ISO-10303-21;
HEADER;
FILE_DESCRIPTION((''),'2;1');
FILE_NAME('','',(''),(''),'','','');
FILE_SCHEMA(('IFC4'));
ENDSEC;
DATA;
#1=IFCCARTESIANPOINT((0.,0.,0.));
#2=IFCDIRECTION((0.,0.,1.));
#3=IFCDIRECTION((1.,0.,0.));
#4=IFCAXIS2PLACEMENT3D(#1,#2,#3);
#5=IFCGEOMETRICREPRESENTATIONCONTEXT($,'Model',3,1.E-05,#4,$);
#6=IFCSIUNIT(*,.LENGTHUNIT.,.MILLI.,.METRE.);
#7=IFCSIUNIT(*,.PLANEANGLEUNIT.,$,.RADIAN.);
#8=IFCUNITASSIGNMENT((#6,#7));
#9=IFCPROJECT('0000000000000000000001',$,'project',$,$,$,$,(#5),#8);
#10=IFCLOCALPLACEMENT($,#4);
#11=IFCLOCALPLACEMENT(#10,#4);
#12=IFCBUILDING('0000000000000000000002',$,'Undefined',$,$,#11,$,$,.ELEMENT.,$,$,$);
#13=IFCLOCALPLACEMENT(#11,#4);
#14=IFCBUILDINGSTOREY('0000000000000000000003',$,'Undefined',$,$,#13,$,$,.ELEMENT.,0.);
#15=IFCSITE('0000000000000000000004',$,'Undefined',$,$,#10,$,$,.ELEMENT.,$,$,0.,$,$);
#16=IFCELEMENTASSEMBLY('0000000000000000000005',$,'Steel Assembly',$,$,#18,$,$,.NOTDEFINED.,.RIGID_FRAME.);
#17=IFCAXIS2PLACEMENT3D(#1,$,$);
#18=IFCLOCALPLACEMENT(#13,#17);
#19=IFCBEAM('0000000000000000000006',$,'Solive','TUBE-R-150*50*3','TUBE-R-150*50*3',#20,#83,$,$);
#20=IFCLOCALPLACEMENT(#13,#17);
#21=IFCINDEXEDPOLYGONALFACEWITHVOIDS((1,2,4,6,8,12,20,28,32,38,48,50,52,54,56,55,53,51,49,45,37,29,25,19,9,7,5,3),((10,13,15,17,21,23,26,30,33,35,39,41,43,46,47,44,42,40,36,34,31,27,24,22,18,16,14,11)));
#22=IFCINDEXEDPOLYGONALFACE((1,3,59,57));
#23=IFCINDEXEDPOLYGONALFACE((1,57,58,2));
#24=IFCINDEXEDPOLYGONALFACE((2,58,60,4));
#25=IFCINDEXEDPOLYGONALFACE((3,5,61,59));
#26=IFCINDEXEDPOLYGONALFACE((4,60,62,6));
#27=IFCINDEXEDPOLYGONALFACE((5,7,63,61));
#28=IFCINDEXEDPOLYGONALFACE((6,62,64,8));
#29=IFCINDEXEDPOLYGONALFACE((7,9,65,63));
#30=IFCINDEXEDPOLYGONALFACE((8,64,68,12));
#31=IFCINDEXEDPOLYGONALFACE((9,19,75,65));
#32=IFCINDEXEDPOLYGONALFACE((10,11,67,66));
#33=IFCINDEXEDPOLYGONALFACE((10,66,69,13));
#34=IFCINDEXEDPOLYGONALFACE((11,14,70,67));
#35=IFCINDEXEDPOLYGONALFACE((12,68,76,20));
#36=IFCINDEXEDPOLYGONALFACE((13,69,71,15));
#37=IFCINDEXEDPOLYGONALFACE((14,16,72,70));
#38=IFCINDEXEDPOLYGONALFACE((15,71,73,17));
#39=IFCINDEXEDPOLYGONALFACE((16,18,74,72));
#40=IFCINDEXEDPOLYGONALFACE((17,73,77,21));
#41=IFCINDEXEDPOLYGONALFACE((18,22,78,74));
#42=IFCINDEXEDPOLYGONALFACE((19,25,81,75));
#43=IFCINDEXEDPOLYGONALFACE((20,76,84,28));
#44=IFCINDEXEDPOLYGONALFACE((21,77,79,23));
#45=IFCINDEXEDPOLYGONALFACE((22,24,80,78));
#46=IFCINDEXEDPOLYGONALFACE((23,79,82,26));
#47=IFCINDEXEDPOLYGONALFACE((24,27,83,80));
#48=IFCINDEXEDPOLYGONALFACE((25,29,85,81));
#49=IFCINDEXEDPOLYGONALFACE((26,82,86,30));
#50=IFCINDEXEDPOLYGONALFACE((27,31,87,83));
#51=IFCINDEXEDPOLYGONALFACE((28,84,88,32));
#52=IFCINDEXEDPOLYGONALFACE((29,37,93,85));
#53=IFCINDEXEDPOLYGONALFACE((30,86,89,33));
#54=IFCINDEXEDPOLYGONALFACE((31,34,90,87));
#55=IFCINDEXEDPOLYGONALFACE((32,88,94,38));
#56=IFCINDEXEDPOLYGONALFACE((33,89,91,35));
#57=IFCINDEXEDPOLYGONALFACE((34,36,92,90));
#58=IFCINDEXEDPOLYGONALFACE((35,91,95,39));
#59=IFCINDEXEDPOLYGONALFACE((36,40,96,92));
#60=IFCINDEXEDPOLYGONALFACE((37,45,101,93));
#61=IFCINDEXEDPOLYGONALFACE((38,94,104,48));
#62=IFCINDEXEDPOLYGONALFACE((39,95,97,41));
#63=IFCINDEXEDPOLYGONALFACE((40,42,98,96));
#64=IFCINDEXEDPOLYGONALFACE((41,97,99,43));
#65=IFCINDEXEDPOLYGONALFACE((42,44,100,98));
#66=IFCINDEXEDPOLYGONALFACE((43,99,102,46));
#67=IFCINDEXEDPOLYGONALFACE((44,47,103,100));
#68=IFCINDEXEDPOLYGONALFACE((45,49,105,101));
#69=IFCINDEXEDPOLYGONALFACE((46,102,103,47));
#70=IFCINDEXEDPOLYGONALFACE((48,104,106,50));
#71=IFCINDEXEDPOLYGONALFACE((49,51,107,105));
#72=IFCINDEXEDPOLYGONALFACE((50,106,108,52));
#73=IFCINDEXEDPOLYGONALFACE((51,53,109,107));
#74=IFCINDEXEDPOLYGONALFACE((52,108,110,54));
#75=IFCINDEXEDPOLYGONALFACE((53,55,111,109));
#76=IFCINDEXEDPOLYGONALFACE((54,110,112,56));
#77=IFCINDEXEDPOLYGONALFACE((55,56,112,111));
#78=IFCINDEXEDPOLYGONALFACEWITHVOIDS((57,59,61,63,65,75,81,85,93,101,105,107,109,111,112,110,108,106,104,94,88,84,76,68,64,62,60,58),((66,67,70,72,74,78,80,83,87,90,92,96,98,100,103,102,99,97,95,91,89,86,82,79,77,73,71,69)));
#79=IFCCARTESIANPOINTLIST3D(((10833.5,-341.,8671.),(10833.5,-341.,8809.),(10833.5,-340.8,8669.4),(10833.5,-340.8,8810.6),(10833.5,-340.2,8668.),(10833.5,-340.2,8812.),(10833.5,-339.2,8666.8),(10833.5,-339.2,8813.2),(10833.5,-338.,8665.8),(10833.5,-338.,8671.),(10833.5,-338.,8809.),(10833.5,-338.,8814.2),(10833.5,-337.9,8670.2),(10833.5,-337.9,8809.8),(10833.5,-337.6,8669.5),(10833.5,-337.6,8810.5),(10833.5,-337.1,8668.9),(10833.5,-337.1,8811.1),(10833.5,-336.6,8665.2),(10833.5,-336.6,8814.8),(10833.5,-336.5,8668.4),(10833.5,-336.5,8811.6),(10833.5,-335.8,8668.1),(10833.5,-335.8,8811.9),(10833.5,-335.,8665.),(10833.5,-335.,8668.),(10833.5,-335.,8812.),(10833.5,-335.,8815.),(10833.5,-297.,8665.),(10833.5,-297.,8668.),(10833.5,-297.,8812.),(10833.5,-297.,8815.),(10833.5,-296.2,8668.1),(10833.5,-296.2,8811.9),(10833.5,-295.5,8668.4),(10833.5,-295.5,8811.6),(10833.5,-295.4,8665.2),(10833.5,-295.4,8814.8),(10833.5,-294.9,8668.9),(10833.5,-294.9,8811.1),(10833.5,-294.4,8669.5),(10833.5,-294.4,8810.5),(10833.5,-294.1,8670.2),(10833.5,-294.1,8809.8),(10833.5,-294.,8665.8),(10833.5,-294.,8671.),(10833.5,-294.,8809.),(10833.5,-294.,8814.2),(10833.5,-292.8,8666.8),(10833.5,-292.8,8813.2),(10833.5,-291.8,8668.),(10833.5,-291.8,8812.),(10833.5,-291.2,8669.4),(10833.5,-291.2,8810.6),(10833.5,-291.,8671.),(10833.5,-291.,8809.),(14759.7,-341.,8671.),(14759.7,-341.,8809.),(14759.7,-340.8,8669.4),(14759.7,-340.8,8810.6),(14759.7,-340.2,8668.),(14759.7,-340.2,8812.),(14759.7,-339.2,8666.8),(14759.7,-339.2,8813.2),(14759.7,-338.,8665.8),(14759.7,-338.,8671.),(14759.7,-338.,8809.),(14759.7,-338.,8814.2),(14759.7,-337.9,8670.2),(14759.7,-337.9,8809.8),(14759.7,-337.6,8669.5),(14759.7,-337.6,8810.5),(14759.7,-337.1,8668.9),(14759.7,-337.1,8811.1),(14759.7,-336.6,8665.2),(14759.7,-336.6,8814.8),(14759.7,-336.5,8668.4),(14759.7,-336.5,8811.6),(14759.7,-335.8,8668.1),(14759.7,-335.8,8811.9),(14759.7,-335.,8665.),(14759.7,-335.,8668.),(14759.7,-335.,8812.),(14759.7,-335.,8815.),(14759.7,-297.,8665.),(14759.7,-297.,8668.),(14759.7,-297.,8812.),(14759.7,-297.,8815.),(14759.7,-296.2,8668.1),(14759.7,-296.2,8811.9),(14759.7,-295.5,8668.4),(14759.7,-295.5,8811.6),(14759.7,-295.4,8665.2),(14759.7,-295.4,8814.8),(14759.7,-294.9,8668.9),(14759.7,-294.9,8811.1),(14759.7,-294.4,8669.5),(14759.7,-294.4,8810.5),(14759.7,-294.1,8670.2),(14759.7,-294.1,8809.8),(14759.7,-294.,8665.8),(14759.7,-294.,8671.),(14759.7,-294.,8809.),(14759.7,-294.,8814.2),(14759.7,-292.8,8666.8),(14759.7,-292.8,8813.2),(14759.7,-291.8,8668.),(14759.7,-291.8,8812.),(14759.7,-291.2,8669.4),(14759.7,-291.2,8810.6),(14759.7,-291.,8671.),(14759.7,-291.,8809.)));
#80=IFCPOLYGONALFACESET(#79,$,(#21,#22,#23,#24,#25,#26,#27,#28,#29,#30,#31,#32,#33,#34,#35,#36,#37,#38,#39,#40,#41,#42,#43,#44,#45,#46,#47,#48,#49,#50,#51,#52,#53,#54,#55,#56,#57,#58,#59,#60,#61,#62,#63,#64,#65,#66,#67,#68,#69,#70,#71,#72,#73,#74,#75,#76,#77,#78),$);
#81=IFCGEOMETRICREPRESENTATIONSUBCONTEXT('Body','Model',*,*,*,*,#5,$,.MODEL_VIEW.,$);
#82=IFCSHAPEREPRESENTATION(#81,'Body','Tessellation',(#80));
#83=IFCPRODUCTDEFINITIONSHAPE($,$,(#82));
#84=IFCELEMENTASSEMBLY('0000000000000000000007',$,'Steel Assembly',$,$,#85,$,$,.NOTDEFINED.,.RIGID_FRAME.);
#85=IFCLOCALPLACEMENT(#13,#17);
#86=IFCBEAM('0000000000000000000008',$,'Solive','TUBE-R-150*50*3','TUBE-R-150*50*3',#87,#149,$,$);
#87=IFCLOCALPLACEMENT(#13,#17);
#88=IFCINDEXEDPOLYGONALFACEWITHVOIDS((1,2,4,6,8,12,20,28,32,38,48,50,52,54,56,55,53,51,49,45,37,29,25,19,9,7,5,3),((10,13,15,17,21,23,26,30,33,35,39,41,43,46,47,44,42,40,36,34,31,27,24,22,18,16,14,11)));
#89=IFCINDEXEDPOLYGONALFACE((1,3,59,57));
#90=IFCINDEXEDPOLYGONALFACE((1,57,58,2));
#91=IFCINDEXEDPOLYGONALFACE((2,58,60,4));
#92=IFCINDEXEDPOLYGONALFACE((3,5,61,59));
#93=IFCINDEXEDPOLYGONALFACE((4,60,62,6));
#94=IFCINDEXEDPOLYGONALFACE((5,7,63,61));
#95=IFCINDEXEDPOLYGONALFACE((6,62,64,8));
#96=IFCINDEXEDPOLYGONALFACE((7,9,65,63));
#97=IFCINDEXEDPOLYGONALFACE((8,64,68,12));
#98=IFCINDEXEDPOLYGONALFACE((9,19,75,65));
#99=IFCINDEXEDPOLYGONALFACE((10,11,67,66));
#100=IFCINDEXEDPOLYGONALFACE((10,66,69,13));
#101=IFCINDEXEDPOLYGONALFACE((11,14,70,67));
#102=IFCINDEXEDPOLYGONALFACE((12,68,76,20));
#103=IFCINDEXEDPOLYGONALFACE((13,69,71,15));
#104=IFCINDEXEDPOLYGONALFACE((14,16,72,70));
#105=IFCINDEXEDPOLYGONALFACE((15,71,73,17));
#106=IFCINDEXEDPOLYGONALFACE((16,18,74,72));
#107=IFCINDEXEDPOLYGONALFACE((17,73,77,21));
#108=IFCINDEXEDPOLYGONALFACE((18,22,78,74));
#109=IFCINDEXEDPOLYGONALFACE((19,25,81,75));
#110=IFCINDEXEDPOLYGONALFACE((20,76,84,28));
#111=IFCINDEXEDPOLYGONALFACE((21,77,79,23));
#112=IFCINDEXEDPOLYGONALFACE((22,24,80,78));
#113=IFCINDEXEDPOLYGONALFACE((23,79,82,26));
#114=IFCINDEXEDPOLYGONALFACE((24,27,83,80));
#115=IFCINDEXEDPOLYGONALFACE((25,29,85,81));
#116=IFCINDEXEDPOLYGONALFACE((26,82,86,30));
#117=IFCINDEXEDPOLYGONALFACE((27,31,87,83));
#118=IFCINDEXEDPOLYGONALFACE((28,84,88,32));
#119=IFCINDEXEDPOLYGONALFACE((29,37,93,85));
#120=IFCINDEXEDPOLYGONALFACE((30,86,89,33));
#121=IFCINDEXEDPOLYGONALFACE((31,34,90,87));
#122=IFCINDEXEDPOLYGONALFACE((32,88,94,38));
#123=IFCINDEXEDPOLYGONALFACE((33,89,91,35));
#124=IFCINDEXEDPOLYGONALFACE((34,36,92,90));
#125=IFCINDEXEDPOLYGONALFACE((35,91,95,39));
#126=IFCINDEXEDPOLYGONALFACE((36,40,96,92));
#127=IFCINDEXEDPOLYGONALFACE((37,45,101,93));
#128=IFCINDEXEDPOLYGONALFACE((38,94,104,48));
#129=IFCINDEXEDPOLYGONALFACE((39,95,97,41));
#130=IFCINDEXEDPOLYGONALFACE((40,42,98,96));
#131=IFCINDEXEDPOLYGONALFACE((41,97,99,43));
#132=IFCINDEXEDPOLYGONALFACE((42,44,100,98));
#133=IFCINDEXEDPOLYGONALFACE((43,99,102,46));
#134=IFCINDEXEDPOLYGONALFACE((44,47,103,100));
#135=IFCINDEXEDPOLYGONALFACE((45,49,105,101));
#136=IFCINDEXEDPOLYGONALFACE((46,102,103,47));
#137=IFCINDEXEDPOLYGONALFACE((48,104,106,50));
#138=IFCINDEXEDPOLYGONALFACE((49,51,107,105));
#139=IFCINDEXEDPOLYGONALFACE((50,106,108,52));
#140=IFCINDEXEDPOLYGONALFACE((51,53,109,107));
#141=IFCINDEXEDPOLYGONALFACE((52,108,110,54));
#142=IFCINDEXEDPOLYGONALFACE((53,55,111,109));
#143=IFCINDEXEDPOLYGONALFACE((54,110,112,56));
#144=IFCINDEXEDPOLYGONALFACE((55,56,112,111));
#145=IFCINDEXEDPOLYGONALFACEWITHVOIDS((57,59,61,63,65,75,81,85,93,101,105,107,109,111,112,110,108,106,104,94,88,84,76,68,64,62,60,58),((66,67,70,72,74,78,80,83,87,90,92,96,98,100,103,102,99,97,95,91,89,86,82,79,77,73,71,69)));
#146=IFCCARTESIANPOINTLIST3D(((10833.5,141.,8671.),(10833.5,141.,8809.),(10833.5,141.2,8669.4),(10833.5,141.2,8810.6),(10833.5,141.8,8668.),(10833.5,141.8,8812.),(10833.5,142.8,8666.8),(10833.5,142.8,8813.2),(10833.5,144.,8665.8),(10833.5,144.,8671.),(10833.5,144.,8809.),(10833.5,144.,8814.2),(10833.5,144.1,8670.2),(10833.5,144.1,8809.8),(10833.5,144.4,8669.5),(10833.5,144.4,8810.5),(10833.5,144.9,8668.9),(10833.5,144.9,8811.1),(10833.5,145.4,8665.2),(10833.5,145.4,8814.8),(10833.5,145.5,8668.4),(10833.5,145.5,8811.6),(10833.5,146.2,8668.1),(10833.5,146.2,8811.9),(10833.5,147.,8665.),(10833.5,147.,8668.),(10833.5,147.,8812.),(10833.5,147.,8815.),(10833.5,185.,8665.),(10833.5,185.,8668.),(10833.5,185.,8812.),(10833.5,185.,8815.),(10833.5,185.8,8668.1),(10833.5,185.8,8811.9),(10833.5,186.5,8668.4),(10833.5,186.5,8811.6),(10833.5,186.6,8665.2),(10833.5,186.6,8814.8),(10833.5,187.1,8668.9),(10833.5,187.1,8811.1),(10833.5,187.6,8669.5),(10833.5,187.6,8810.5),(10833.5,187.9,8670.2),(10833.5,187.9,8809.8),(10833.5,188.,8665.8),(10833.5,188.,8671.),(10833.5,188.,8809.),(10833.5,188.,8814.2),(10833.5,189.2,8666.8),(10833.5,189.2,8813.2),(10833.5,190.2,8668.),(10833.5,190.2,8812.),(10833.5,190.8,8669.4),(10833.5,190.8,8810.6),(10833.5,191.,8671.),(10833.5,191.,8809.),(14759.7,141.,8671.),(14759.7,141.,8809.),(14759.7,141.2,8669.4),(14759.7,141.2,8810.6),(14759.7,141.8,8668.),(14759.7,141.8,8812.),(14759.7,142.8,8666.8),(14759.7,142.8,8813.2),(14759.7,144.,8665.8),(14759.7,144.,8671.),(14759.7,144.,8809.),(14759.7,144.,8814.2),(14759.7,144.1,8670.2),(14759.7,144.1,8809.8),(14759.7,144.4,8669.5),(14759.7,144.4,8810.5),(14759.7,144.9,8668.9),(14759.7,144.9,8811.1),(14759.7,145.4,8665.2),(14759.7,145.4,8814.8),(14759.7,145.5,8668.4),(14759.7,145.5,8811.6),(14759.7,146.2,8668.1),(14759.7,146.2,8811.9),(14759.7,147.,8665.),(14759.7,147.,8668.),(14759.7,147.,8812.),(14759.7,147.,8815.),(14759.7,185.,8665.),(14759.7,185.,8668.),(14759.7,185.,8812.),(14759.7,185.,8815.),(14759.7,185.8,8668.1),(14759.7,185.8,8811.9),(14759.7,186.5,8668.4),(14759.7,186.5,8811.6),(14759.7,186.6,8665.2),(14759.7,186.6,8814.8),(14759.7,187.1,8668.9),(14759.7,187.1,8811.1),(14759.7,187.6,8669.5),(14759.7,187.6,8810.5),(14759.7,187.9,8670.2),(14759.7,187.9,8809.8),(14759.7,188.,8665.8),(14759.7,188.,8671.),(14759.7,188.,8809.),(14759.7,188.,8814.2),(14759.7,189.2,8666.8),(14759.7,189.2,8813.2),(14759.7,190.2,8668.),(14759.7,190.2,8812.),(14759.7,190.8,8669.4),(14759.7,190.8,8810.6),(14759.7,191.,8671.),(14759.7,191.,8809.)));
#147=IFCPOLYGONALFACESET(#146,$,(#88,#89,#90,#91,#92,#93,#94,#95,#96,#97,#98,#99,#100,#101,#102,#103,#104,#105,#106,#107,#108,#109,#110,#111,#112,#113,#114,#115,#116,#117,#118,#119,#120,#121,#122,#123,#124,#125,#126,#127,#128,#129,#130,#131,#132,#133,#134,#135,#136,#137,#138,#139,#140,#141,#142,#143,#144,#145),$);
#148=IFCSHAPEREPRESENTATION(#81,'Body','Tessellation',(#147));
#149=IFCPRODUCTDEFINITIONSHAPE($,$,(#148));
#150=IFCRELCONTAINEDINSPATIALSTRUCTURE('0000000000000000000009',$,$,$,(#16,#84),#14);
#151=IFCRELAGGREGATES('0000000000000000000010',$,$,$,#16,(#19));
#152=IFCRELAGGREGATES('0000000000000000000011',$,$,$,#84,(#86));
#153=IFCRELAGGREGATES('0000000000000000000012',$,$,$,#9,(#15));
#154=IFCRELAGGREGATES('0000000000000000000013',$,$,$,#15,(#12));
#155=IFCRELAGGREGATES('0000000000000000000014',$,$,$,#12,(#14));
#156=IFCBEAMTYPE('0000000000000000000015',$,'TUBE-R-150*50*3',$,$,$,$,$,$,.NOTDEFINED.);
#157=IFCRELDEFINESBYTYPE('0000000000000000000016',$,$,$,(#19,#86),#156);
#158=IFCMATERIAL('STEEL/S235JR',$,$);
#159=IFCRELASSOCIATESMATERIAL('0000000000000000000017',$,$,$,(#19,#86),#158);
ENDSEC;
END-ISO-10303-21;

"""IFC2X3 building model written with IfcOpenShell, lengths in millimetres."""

from ifc_helpers import new_model, si_unit, frame, origin_with_axes, origin_2d_with_axis, place, context, subcontext, project, spatial, hollow_rectangle, extrude, material, type_object, element, aggregate, save


model = new_model("IFC2X3")

# Units and contexts
model_context = context("Model", 3, precision=1e-05, world=origin_with_axes())
body_context = subcontext(model_context, "Body", "Model", "MODEL_VIEW")
ifc_project = project(units=[si_unit("LENGTHUNIT", "METRE", prefix="MILLI"), si_unit("PLANEANGLEUNIT", "RADIAN")], contexts=[model_context])

# Site, building, storey
site_placement = place(None, origin_with_axes())
site = spatial("IfcSite", under=ifc_project, at=site_placement, Name="Undefined", CompositionType="ELEMENT", RefElevation=0.0)
building_placement = place(site_placement, origin_with_axes())
building = spatial("IfcBuilding", under=site, at=building_placement, Name="Undefined", CompositionType="ELEMENT")
storey_placement = place(building_placement, origin_with_axes())
storey = spatial("IfcBuildingStorey", under=building, at=storey_placement, Name="Undefined", CompositionType="ELEMENT", Elevation=0.0)

# Element assemblies, beams
ifc_material_1 = material(Name="STEEL/S235JR")
beam_type_1 = type_object("IfcBeamType", Name="TUBE-R-150*50*3", PredefinedType="NOTDEFINED")
assembly_1_placement = place(storey_placement, origin_with_axes())
assembly_1 = element("IfcElementAssembly", 1, at=assembly_1_placement, inside=storey, Name="Steel Assembly", AssemblyPlace="NOTDEFINED", PredefinedType="RIGID_FRAME")
beam_1_placement = place(assembly_1_placement, frame((14759.7, -316.0, 8740.0), z_axis=(0.0, 0.0, 1.0), x_axis=(-1.0, 0.0, 0.0)))
beam_1 = element("IfcBeam", 2, at=beam_1_placement, type_object=beam_type_1, material=ifc_material_1, Name="Solive", Description="TUBE-R-150*50*3", ObjectType="TUBE-R-150*50*3", context=body_context, shape_type="SweptSolid", body=[
    extrude(hollow_rectangle(XDim=50.0, YDim=150.0, WallThickness=3.0, InnerFilletRadius=3.0, OuterFilletRadius=6.0, at=origin_2d_with_axis()), frame((3926.2, 0.0, 0.0), z_axis=(-1.0, 0.0, 0.0), x_axis=(0.0, -1.0, 0.0)), (0.0, 0.0, 1.0), 3926.2),
])
aggregate(assembly_1, [beam_1])
assembly_2_placement = place(storey_placement, origin_with_axes())
assembly_2 = element("IfcElementAssembly", 3, at=assembly_2_placement, inside=storey, Name="Steel Assembly", AssemblyPlace="NOTDEFINED", PredefinedType="RIGID_FRAME")
beam_2_placement = place(assembly_2_placement, frame((14759.7, 166.0, 8740.0), z_axis=(0.0, 0.0, 1.0), x_axis=(-1.0, 0.0, 0.0)))
beam_2 = element("IfcBeam", 4, at=beam_2_placement, type_object=beam_type_1, material=ifc_material_1, Name="Solive", Description="TUBE-R-150*50*3", ObjectType="TUBE-R-150*50*3", context=body_context, shape_type="SweptSolid", body=[
    extrude(hollow_rectangle(XDim=50.0, YDim=150.0, WallThickness=3.0, InnerFilletRadius=3.0, OuterFilletRadius=6.0, at=origin_2d_with_axis()), frame((3926.2, 0.0, 0.0), z_axis=(-1.0, 0.0, 0.0), x_axis=(0.0, -1.0, 0.0)), (0.0, 0.0, 1.0), 3926.2),
])
aggregate(assembly_2, [beam_2])

save(model, "model.ifc")
